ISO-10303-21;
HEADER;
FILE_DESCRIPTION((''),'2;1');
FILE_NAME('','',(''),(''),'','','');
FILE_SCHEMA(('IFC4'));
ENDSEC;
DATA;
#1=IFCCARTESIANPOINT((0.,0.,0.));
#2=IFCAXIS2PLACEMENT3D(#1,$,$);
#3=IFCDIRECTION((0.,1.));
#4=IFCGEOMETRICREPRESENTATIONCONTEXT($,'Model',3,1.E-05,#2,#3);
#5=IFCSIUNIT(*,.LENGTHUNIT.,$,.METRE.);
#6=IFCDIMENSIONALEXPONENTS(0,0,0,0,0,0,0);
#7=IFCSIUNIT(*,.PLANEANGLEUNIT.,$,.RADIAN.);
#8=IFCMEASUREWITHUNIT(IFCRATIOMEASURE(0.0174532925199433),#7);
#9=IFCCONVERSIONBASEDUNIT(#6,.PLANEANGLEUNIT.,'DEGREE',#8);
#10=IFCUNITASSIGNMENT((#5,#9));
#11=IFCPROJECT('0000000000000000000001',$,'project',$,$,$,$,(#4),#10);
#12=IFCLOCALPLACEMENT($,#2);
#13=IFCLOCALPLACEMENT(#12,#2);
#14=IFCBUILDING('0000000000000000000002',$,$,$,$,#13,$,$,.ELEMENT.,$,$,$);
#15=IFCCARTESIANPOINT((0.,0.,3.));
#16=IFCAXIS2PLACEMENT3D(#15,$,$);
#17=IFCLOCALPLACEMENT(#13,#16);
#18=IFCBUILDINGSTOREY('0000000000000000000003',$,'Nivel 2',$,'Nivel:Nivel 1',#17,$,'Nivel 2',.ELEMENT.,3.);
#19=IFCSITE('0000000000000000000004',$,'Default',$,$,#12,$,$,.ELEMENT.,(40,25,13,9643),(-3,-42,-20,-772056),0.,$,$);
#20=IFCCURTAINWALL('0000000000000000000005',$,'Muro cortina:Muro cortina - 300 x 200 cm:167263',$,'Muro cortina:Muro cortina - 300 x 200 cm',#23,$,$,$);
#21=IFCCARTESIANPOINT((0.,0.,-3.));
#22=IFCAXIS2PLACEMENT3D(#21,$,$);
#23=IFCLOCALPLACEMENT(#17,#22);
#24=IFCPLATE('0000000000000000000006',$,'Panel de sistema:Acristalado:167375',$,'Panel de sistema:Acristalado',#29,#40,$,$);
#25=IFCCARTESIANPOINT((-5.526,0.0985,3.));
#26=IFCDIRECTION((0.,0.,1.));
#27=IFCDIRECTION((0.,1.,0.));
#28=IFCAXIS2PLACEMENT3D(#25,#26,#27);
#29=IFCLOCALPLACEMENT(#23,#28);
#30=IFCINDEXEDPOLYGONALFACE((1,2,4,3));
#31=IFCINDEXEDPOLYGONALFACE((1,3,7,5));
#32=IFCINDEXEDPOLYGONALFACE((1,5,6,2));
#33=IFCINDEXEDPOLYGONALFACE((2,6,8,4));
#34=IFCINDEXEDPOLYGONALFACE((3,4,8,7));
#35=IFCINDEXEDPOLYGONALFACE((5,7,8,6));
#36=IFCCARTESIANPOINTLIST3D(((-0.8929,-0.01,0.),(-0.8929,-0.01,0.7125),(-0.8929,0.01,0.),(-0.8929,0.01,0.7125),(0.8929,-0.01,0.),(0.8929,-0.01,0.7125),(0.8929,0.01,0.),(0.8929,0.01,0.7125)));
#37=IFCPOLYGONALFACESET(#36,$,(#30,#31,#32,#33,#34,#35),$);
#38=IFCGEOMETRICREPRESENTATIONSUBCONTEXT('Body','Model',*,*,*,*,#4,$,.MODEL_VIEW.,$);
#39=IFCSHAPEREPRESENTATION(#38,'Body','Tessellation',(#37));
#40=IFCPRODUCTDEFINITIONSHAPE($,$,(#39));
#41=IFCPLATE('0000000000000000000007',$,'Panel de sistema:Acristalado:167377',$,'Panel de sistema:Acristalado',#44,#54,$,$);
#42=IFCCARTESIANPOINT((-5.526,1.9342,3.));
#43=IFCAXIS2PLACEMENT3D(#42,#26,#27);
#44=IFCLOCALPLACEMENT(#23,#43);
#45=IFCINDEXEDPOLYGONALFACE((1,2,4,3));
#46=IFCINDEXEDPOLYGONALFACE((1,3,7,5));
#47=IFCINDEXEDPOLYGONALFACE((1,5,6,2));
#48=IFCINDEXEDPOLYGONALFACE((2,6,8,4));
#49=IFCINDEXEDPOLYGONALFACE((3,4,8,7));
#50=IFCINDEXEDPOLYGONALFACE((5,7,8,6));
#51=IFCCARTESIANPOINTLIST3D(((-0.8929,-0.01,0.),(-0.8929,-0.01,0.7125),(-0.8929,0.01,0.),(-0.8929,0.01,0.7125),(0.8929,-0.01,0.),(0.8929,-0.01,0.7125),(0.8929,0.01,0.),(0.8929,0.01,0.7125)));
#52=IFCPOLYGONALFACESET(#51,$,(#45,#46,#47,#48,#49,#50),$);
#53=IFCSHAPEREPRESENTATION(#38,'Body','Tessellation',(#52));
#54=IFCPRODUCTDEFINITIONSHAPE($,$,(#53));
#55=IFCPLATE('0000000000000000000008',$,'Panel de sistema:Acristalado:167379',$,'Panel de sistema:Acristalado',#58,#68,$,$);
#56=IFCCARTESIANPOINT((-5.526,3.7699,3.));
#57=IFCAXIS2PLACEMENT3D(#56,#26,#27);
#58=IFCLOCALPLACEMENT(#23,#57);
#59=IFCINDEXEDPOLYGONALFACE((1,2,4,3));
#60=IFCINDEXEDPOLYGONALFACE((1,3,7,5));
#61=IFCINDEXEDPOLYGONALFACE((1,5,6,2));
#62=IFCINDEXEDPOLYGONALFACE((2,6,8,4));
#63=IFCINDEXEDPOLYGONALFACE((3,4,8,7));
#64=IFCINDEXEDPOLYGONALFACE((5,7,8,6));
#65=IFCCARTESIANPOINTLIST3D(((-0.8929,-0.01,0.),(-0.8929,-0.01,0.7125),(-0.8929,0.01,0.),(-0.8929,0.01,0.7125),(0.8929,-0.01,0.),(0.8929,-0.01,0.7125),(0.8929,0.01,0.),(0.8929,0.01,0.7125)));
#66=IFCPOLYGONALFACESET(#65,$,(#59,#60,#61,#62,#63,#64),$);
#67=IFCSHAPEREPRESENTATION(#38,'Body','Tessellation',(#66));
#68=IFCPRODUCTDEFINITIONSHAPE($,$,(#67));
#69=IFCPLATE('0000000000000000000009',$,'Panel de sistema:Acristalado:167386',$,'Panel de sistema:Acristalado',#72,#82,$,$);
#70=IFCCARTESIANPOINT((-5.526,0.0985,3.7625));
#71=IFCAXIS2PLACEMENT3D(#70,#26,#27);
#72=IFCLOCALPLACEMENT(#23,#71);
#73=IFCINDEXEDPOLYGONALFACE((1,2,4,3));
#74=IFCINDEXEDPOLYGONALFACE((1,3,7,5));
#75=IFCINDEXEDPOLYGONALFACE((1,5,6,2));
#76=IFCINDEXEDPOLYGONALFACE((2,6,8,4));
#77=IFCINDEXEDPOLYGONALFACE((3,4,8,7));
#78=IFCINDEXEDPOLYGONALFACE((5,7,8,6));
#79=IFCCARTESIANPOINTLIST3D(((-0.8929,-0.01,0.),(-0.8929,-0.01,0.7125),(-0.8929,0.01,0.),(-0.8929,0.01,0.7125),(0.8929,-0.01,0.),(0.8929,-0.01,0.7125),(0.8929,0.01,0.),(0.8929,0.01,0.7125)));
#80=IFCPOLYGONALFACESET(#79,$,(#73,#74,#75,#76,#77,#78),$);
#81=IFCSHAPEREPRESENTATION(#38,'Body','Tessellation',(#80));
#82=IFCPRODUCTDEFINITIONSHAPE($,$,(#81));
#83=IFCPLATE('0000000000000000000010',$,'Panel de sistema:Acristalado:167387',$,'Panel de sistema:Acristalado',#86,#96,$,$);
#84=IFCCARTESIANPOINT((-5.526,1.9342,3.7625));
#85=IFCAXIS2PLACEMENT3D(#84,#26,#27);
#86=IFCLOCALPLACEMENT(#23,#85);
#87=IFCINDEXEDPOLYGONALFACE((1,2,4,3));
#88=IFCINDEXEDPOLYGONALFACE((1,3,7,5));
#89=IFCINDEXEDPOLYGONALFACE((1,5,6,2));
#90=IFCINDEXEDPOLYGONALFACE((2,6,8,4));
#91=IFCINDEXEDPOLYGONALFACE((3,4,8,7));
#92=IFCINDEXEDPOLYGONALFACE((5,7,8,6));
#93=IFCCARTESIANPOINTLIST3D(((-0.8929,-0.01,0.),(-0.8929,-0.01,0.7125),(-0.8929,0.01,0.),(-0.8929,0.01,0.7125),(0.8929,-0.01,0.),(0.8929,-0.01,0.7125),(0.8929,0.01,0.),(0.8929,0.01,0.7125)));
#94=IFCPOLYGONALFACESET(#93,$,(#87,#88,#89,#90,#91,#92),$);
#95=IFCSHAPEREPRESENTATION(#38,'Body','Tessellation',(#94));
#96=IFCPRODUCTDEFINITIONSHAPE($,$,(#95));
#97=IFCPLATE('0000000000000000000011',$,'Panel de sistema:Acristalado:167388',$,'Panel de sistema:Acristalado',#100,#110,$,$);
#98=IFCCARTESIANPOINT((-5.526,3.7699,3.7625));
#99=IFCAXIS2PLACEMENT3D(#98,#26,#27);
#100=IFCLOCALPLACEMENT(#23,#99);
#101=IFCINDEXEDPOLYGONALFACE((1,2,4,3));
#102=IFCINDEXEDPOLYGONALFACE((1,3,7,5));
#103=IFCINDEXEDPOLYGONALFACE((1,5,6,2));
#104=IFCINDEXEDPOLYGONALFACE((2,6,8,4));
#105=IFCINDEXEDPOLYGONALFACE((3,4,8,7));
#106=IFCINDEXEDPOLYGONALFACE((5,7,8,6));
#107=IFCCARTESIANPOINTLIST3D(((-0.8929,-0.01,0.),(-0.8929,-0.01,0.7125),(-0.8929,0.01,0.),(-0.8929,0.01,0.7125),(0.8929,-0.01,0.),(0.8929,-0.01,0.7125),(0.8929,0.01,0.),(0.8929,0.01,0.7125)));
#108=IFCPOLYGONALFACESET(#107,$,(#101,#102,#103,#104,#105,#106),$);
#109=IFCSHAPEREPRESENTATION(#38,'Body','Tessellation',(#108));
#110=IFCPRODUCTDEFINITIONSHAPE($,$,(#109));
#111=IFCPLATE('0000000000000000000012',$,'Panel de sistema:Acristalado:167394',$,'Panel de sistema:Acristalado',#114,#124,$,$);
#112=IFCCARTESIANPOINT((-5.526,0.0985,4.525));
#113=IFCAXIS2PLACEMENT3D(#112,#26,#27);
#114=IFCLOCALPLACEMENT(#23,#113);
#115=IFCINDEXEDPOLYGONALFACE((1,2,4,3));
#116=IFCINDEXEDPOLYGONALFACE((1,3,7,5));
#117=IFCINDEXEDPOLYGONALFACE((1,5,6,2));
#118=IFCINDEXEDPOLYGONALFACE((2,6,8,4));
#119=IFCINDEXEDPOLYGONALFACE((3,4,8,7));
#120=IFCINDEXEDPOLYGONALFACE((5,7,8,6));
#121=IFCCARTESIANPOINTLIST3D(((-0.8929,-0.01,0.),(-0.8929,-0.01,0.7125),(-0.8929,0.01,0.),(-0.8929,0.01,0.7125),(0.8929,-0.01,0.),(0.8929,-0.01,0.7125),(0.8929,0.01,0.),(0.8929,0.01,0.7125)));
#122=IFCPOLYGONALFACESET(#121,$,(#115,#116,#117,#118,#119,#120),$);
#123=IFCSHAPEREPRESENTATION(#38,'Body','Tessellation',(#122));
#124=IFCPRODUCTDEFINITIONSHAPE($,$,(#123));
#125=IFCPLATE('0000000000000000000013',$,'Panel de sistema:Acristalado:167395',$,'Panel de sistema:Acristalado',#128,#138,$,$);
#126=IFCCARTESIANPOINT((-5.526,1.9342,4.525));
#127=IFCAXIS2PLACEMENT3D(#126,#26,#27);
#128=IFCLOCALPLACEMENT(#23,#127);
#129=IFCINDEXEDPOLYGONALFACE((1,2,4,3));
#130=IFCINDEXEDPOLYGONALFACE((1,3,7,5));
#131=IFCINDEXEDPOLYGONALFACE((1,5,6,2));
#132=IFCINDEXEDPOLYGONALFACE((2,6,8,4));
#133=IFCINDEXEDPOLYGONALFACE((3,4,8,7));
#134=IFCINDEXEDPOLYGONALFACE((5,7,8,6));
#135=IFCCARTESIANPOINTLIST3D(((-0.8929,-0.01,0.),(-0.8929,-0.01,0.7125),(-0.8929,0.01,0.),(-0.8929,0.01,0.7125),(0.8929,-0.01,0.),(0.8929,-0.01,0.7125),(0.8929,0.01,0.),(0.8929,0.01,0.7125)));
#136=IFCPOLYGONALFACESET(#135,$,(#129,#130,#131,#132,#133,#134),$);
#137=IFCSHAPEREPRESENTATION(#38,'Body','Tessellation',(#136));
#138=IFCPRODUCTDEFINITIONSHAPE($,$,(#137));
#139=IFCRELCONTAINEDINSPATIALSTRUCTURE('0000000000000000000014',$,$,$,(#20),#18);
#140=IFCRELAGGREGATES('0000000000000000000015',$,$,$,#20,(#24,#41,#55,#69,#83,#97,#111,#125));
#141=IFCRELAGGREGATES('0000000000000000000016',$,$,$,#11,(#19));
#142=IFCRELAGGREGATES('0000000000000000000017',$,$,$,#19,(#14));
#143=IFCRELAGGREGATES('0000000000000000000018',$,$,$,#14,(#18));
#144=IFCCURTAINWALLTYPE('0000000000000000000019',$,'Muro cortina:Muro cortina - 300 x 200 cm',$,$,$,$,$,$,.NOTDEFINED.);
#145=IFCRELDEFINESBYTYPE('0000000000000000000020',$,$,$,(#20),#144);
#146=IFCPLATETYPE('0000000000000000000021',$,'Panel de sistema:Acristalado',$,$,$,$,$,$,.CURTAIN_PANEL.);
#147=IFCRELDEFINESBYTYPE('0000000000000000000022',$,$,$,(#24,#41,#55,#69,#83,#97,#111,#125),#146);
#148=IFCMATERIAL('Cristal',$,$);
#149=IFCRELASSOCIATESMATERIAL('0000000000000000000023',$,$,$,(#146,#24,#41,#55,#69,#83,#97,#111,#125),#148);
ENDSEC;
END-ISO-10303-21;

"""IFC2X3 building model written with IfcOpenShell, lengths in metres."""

from ifc_helpers import new_model, entity, si_unit, converted_unit, direction, frame, origin, origin_2d_with_axis, place, context, subcontext, project, spatial, rectangle, extrude, source, transform, mapped, material, type_object, type_shapes, element, aggregate, save


model = new_model("IFC2X3")

# Units and contexts
model_context = context("Model", 3, precision=1e-05, world=origin(), true_north=direction((0.0, 1.0)))
body_context = subcontext(model_context, "Body", "Model", "MODEL_VIEW")
ifc_project = project(units=[si_unit("LENGTHUNIT", "METRE"), converted_unit("PLANEANGLEUNIT", "DEGREE", entity("IfcRatioMeasure", 0.0174532925199433), si_unit("PLANEANGLEUNIT", "RADIAN"), dimensions=[0, 0, 0, 0, 0, 0, 0])], contexts=[model_context])

# Site, building, storey
site_placement = place(None, origin())
site = spatial("IfcSite", under=ifc_project, at=site_placement, Name="Default", CompositionType="ELEMENT", RefLatitude=(40, 25, 13, 9643), RefLongitude=(-3, -42, -20, -772056), RefElevation=0.0)
building_placement = place(site_placement, origin())
building = spatial("IfcBuilding", under=site, at=building_placement, CompositionType="ELEMENT")
storey_placement = place(building_placement, frame((0.0, 0.0, 3.0)))
storey = spatial("IfcBuildingStorey", under=building, at=storey_placement, Name="Nivel 2", ObjectType="Nivel:Nivel 1", LongName="Nivel 2", CompositionType="ELEMENT", Elevation=3.0)

# Curtain wall, plates
curtain_wall_type = type_object("IfcCurtainWallType", Name="Muro cortina:Muro cortina - 300 x 200 cm", PredefinedType="NOTDEFINED")
curtain_wall_placement = place(storey_placement, frame((0.0, 0.0, -3.0)))
curtain_wall = element("IfcCurtainWall", 1, at=curtain_wall_placement, inside=storey, type_object=curtain_wall_type, Name="Muro cortina:Muro cortina - 300 x 200 cm:167263", ObjectType="Muro cortina:Muro cortina - 300 x 200 cm")
ifc_material_1 = material(Name="Cristal")
plate_type = type_object("IfcPlateType", Name="Panel de sistema:Acristalado", PredefinedType="CURTAIN_PANEL", material=ifc_material_1)
shared_shape_1 = source(origin(), body_context, "Body", "SweptSolid", [
    extrude(rectangle(XDim=0.02, YDim=1.7857, at=origin_2d_with_axis()), frame((0.0, 0.0, 0.0), z_axis=(0.0, 0.0, 1.0), x_axis=(0.0, 1.0, 0.0)), (0.0, 0.0, 1.0), 0.7125),
])
type_shapes(plate_type, [shared_shape_1])
plate_1_placement = place(curtain_wall_placement, frame((-5.526, 0.0985, 3.0), z_axis=(0.0, 0.0, 1.0), x_axis=(0.0, 1.0, 0.0)))
plate_1 = element("IfcPlate", 2, at=plate_1_placement, type_object=plate_type, material=ifc_material_1, Name="Panel de sistema:Acristalado:167375", ObjectType="Panel de sistema:Acristalado", context=body_context, shape_type="MappedRepresentation", body=[
    mapped(shared_shape_1, transform((0.0, 0.0, 0.0), scale=1.0)),
])
plate_2_placement = place(curtain_wall_placement, frame((-5.526, 1.9342, 3.0), z_axis=(0.0, 0.0, 1.0), x_axis=(0.0, 1.0, 0.0)))
plate_2 = element("IfcPlate", 3, at=plate_2_placement, type_object=plate_type, material=ifc_material_1, Name="Panel de sistema:Acristalado:167377", ObjectType="Panel de sistema:Acristalado", context=body_context, shape_type="MappedRepresentation", body=[
    mapped(shared_shape_1, transform((0.0, 0.0, 0.0), scale=1.0)),
])
plate_3_placement = place(curtain_wall_placement, frame((-5.526, 3.7699, 3.0), z_axis=(0.0, 0.0, 1.0), x_axis=(0.0, 1.0, 0.0)))
plate_3 = element("IfcPlate", 4, at=plate_3_placement, type_object=plate_type, material=ifc_material_1, Name="Panel de sistema:Acristalado:167379", ObjectType="Panel de sistema:Acristalado", context=body_context, shape_type="MappedRepresentation", body=[
    mapped(shared_shape_1, transform((0.0, 0.0, 0.0), scale=1.0)),
])
plate_4_placement = place(curtain_wall_placement, frame((-5.526, 0.0985, 3.7625), z_axis=(0.0, 0.0, 1.0), x_axis=(0.0, 1.0, 0.0)))
plate_4 = element("IfcPlate", 5, at=plate_4_placement, type_object=plate_type, material=ifc_material_1, Name="Panel de sistema:Acristalado:167386", ObjectType="Panel de sistema:Acristalado", context=body_context, shape_type="MappedRepresentation", body=[
    mapped(shared_shape_1, transform((0.0, 0.0, 0.0), scale=1.0)),
])
plate_5_placement = place(curtain_wall_placement, frame((-5.526, 1.9342, 3.7625), z_axis=(0.0, 0.0, 1.0), x_axis=(0.0, 1.0, 0.0)))
plate_5 = element("IfcPlate", 6, at=plate_5_placement, type_object=plate_type, material=ifc_material_1, Name="Panel de sistema:Acristalado:167387", ObjectType="Panel de sistema:Acristalado", context=body_context, shape_type="MappedRepresentation", body=[
    mapped(shared_shape_1, transform((0.0, 0.0, 0.0), scale=1.0)),
])
plate_6_placement = place(curtain_wall_placement, frame((-5.526, 3.7699, 3.7625), z_axis=(0.0, 0.0, 1.0), x_axis=(0.0, 1.0, 0.0)))
plate_6 = element("IfcPlate", 7, at=plate_6_placement, type_object=plate_type, material=ifc_material_1, Name="Panel de sistema:Acristalado:167388", ObjectType="Panel de sistema:Acristalado", context=body_context, shape_type="MappedRepresentation", body=[
    mapped(shared_shape_1, transform((0.0, 0.0, 0.0), scale=1.0)),
])
plate_7_placement = place(curtain_wall_placement, frame((-5.526, 0.0985, 4.525), z_axis=(0.0, 0.0, 1.0), x_axis=(0.0, 1.0, 0.0)))
plate_7 = element("IfcPlate", 8, at=plate_7_placement, type_object=plate_type, material=ifc_material_1, Name="Panel de sistema:Acristalado:167394", ObjectType="Panel de sistema:Acristalado", context=body_context, shape_type="MappedRepresentation", body=[
    mapped(shared_shape_1, transform((0.0, 0.0, 0.0), scale=1.0)),
])
plate_8_placement = place(curtain_wall_placement, frame((-5.526, 1.9342, 4.525), z_axis=(0.0, 0.0, 1.0), x_axis=(0.0, 1.0, 0.0)))
plate_8 = element("IfcPlate", 9, at=plate_8_placement, type_object=plate_type, material=ifc_material_1, Name="Panel de sistema:Acristalado:167395", ObjectType="Panel de sistema:Acristalado", context=body_context, shape_type="MappedRepresentation", body=[
    mapped(shared_shape_1, transform((0.0, 0.0, 0.0), scale=1.0)),
])
aggregate(curtain_wall, [plate_1, plate_2, plate_3, plate_4, plate_5, plate_6, plate_7, plate_8])

save(model, "model.ifc")
